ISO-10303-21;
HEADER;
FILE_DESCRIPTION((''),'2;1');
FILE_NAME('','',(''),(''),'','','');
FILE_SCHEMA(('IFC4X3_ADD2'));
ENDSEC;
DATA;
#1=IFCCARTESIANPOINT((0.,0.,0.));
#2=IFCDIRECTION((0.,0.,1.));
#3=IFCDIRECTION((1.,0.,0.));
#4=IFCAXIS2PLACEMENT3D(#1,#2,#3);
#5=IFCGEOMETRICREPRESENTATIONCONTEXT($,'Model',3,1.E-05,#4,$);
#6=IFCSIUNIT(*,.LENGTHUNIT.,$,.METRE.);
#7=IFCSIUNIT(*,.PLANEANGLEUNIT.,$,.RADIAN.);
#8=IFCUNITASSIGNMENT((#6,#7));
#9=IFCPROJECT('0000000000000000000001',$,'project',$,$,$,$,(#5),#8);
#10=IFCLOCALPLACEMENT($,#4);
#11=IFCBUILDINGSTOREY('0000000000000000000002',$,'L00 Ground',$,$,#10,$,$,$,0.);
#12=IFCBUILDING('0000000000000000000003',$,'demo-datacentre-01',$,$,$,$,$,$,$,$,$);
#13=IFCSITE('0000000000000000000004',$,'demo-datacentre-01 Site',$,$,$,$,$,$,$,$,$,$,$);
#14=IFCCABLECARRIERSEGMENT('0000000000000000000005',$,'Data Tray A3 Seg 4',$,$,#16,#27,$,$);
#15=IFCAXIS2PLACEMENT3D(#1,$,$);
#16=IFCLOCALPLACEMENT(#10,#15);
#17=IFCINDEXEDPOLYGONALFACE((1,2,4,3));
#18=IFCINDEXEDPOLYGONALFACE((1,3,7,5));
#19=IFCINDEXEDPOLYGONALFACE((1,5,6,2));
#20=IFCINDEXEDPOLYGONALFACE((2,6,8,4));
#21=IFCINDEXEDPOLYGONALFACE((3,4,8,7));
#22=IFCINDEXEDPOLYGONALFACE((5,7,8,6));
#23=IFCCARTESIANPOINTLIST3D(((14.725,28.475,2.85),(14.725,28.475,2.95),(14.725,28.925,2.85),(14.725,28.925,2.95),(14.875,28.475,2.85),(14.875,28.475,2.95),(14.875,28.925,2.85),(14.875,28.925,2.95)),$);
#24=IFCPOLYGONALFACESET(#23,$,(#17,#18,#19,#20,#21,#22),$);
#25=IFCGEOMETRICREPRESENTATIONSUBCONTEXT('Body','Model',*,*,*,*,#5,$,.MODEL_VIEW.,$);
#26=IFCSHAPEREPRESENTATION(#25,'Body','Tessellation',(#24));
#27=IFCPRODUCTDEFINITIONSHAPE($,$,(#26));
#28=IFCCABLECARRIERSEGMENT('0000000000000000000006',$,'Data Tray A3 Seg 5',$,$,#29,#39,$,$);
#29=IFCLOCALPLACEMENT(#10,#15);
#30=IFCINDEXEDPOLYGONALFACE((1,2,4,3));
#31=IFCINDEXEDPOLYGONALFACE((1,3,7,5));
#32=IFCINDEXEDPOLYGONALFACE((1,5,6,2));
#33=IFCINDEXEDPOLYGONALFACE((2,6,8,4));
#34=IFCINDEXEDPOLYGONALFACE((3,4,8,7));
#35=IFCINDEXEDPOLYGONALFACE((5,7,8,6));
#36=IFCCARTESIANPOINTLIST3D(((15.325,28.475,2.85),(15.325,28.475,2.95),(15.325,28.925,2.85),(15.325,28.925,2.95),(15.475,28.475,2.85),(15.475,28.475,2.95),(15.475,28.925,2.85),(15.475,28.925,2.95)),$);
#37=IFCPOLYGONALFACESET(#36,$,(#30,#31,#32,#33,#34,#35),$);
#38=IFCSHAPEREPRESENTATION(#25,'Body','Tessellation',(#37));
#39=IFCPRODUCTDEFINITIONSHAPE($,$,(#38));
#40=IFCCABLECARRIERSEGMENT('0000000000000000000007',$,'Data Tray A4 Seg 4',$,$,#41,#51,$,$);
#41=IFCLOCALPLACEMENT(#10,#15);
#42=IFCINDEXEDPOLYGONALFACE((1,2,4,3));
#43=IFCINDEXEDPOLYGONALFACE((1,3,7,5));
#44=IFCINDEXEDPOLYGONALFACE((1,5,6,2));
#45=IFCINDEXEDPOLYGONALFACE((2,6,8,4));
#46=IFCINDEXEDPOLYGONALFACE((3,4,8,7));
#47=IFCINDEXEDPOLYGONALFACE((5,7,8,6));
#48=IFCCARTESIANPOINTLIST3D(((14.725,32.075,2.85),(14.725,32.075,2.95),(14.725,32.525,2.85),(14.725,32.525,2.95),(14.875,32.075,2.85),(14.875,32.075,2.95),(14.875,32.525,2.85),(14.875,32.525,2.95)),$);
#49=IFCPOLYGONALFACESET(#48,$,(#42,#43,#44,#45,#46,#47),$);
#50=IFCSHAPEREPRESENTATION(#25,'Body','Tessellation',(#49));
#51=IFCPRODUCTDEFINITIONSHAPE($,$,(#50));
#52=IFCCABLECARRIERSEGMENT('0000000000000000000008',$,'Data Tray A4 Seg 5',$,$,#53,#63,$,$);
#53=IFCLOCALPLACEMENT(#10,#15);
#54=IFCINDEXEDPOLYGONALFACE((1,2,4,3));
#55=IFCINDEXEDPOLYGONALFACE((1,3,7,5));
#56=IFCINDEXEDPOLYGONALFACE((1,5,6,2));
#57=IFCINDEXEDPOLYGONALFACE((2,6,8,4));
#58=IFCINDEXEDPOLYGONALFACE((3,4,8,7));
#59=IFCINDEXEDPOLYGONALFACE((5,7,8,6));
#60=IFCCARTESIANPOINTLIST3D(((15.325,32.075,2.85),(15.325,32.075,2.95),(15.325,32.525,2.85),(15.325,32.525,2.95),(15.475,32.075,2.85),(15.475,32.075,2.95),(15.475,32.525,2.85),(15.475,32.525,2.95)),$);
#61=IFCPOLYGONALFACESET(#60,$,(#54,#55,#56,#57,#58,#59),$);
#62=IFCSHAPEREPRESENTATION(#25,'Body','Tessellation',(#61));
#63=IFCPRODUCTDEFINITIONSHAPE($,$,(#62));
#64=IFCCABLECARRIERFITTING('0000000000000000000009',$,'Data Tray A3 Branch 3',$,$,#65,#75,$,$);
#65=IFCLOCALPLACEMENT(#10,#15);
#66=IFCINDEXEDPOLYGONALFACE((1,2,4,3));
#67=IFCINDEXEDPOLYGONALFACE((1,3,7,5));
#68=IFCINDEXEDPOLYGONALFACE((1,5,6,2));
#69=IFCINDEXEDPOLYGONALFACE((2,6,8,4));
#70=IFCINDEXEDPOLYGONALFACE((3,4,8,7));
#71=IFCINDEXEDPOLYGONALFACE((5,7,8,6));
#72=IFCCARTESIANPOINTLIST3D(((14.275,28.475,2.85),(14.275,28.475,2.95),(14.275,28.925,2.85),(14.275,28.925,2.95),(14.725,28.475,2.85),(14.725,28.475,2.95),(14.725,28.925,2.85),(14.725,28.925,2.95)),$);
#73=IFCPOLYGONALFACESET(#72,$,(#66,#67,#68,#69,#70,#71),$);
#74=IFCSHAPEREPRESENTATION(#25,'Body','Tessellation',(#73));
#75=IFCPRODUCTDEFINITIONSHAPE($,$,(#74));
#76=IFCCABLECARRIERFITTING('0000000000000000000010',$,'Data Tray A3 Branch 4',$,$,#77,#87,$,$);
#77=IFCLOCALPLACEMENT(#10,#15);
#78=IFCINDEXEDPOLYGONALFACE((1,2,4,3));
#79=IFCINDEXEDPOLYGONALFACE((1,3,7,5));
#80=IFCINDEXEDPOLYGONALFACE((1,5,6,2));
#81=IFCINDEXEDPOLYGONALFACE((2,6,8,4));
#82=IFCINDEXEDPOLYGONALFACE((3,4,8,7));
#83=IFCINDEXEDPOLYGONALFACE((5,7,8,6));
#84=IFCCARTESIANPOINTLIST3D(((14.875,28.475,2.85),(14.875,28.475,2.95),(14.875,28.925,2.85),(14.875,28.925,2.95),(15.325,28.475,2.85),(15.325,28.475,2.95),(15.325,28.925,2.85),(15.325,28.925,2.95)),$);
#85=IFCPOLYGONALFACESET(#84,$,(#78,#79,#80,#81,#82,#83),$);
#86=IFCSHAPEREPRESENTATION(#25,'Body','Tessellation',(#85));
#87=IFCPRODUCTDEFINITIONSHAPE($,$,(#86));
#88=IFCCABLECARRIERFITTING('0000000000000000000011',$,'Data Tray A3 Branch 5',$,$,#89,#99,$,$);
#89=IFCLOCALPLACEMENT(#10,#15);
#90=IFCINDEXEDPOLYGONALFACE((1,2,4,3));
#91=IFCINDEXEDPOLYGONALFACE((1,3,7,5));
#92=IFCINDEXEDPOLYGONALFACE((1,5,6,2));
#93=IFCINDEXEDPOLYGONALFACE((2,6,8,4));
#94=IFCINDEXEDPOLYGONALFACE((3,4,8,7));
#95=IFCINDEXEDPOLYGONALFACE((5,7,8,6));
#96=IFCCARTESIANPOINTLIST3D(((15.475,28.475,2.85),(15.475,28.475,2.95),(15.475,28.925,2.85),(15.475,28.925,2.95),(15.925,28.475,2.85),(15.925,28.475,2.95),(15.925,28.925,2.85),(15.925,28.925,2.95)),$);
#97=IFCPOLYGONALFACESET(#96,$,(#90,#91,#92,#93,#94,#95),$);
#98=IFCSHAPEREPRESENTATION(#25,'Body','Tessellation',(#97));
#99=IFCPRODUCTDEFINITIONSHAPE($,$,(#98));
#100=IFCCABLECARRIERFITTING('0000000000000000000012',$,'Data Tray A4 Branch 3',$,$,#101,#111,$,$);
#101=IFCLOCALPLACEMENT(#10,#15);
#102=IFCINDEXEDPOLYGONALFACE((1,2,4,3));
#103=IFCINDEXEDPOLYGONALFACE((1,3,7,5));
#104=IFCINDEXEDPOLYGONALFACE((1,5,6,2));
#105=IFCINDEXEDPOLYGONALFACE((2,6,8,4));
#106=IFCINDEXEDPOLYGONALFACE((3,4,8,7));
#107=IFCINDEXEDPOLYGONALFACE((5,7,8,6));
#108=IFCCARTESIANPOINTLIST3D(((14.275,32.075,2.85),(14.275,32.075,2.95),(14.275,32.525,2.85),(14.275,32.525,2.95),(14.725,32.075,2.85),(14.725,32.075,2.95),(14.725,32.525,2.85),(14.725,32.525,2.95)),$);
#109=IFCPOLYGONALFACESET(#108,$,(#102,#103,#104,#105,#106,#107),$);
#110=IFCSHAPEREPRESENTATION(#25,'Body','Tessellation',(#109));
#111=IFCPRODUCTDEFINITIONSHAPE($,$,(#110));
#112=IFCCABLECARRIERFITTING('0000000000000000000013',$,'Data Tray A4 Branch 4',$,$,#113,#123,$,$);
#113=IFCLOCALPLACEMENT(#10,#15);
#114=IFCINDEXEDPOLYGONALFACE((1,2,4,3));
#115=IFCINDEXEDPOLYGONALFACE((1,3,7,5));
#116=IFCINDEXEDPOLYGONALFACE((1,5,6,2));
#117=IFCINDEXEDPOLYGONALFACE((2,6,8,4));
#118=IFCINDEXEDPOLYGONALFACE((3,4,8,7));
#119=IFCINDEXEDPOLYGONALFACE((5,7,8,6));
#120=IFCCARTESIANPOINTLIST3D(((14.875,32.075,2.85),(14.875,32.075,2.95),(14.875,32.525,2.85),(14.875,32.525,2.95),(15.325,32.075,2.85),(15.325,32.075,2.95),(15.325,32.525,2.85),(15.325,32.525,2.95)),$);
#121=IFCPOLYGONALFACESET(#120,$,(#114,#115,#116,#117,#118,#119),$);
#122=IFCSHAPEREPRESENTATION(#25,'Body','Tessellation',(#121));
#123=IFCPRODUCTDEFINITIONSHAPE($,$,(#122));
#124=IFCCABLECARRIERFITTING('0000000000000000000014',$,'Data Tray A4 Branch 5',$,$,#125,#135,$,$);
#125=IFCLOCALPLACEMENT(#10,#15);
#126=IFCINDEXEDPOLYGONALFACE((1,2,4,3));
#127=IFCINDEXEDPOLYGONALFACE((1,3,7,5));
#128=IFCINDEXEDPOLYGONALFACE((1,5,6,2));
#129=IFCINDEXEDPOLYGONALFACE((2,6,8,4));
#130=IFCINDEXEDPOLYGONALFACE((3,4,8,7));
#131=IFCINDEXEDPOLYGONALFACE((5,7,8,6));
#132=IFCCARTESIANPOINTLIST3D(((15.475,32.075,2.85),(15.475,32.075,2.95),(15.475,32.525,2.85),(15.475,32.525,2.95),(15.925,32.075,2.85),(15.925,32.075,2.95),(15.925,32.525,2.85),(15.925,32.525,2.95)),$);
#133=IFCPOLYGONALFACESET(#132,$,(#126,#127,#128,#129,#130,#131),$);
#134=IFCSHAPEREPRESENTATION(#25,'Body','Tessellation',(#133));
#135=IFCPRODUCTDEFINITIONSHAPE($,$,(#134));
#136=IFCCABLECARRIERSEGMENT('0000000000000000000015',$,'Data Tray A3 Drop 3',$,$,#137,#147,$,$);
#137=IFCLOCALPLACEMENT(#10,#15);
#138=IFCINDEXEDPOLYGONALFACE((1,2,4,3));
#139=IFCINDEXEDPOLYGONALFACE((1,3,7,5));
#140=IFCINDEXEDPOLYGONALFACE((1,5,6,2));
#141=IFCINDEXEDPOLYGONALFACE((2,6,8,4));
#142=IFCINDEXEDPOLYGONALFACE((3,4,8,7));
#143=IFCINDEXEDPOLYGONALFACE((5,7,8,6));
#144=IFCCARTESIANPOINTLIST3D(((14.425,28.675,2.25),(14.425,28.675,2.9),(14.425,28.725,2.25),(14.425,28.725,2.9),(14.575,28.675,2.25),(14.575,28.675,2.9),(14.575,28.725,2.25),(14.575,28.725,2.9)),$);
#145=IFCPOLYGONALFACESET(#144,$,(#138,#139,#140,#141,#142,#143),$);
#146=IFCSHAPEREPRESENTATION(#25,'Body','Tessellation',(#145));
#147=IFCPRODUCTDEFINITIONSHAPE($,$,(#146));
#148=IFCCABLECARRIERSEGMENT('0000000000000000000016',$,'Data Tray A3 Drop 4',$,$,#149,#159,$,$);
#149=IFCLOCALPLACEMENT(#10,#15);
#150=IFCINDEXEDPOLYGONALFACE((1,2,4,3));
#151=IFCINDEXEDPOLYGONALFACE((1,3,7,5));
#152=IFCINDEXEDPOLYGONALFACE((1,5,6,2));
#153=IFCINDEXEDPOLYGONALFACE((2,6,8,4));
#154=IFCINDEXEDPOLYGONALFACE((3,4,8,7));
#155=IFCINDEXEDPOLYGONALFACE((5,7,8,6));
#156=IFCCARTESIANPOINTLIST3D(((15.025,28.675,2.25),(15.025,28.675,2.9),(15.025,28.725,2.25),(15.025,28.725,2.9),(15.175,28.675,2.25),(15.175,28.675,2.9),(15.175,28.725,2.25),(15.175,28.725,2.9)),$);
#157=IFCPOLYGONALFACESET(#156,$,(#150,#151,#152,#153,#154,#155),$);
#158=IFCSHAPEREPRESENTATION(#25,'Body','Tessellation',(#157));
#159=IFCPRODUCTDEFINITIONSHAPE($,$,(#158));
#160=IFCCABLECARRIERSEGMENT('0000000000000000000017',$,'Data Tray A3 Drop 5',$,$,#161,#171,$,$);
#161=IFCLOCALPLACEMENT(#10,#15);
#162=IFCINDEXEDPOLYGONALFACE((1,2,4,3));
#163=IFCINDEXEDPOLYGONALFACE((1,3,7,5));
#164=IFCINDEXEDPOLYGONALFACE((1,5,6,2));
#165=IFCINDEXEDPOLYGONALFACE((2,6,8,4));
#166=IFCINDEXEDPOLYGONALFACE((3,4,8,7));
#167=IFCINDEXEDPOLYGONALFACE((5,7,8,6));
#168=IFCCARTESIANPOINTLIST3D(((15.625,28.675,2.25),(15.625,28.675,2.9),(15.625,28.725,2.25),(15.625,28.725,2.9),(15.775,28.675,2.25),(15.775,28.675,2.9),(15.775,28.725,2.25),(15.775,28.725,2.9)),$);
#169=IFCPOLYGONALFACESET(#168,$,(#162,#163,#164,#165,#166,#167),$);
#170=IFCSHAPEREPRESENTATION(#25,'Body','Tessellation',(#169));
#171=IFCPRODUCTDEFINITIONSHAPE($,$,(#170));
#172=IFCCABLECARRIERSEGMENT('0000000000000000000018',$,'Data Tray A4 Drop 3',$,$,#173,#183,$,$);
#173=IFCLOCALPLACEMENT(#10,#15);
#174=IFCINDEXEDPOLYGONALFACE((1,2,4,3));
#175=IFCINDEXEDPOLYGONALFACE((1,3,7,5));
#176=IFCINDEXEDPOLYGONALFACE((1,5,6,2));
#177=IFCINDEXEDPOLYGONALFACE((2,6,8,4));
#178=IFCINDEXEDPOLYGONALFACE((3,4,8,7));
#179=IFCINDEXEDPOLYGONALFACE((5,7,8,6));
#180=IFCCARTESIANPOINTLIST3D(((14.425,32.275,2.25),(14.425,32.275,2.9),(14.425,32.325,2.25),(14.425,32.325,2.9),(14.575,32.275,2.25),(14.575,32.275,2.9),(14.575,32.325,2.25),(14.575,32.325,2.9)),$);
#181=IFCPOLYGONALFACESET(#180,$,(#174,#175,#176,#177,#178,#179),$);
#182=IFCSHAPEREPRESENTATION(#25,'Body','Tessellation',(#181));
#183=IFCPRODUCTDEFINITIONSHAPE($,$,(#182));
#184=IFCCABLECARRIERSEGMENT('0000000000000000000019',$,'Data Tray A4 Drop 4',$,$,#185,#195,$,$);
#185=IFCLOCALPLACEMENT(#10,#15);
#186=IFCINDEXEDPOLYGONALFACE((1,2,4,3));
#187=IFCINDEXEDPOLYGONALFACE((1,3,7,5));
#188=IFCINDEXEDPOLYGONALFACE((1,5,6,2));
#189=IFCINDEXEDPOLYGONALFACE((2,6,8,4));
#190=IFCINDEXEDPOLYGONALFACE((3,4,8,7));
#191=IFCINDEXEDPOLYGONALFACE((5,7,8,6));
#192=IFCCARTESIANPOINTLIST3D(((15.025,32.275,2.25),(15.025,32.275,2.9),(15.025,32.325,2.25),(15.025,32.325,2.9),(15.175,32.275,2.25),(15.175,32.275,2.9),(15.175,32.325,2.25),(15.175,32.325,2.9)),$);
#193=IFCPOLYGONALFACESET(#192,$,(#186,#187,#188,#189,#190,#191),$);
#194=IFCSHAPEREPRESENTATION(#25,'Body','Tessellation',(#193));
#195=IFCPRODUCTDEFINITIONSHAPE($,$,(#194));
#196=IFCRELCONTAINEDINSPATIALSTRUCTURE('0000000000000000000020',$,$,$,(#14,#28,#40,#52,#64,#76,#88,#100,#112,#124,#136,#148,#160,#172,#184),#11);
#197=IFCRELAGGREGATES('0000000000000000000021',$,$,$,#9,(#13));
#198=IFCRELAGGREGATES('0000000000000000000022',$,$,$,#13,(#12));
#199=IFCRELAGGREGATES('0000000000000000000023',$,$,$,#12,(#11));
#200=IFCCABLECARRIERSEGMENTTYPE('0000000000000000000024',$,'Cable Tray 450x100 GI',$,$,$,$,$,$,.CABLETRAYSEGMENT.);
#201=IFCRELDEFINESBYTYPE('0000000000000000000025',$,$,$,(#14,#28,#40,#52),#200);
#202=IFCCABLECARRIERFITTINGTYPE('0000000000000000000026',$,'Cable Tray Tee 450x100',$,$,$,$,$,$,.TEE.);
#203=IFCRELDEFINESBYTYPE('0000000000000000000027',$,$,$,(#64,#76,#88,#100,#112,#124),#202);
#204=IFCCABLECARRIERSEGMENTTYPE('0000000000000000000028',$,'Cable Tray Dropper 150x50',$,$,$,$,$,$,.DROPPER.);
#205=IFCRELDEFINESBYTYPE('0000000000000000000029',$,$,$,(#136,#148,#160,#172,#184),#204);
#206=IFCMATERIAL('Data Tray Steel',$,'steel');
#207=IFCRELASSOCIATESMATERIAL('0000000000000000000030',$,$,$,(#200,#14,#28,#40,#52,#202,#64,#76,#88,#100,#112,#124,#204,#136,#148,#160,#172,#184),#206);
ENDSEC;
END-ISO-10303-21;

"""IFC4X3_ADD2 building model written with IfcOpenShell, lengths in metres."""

from ifc_helpers import new_model, si_unit, frame, origin_with_axes, place, context, subcontext, project, spatial, rectangle, extrude, material, type_object, element, save


model = new_model("IFC4X3_ADD2")

# Units and contexts
model_context = context("Model", 3, precision=1e-05, world=origin_with_axes())
body_context = subcontext(model_context, "Body", "Model", "MODEL_VIEW")
ifc_project = project(units=[si_unit("LENGTHUNIT", "METRE"), si_unit("PLANEANGLEUNIT", "RADIAN")], contexts=[model_context])

# Site, building, storey
site = spatial("IfcSite", under=ifc_project, Name="demo-datacentre-01 Site")
building = spatial("IfcBuilding", under=site, Name="demo-datacentre-01")
storey_placement = place(None, origin_with_axes())
storey = spatial("IfcBuildingStorey", under=building, at=storey_placement, Name="L00 Ground", Elevation=0.0)

# Cable carrier segments
ifc_material_1 = material(Name="Data Tray Steel", Category="steel")
cable_carrier_segment_type_1 = type_object("IfcCableCarrierSegmentType", Name="Cable Tray 450x100 GI", PredefinedType="CABLETRAYSEGMENT", material=ifc_material_1)
cable_carrier_segment_1_placement = place(storey_placement, frame((14.725, 28.7, 2.9), z_axis=(1.0, 0.0, 0.0), x_axis=(0.0, 1.0, 0.0)))
element("IfcCableCarrierSegment", 1, at=cable_carrier_segment_1_placement, inside=storey, type_object=cable_carrier_segment_type_1, material=ifc_material_1, Name="Data Tray A3 Seg 4", context=body_context, shape_type="SweptSolid", body=[
    extrude(rectangle(XDim=0.45, YDim=0.1), origin_with_axes(), (0.0, 0.0, 1.0), 0.15),
])
cable_carrier_segment_2_placement = place(storey_placement, frame((15.325, 28.7, 2.9), z_axis=(1.0, 0.0, 0.0), x_axis=(0.0, 1.0, 0.0)))
element("IfcCableCarrierSegment", 2, at=cable_carrier_segment_2_placement, inside=storey, type_object=cable_carrier_segment_type_1, material=ifc_material_1, Name="Data Tray A3 Seg 5", context=body_context, shape_type="SweptSolid", body=[
    extrude(rectangle(XDim=0.45, YDim=0.1), origin_with_axes(), (0.0, 0.0, 1.0), 0.15),
])
cable_carrier_segment_3_placement = place(storey_placement, frame((14.725, 32.3, 2.9), z_axis=(1.0, 0.0, 0.0), x_axis=(0.0, 1.0, 0.0)))
element("IfcCableCarrierSegment", 3, at=cable_carrier_segment_3_placement, inside=storey, type_object=cable_carrier_segment_type_1, material=ifc_material_1, Name="Data Tray A4 Seg 4", context=body_context, shape_type="SweptSolid", body=[
    extrude(rectangle(XDim=0.45, YDim=0.1), origin_with_axes(), (0.0, 0.0, 1.0), 0.15),
])
cable_carrier_segment_4_placement = place(storey_placement, frame((15.325, 32.3, 2.9), z_axis=(1.0, 0.0, 0.0), x_axis=(0.0, 1.0, 0.0)))
element("IfcCableCarrierSegment", 4, at=cable_carrier_segment_4_placement, inside=storey, type_object=cable_carrier_segment_type_1, material=ifc_material_1, Name="Data Tray A4 Seg 5", context=body_context, shape_type="SweptSolid", body=[
    extrude(rectangle(XDim=0.45, YDim=0.1), origin_with_axes(), (0.0, 0.0, 1.0), 0.15),
])

# Cable carrier fittings
cable_carrier_fitting_type = type_object("IfcCableCarrierFittingType", Name="Cable Tray Tee 450x100", PredefinedType="TEE", material=ifc_material_1)
for number, where, z_axis, x_axis, name in (
    (5, (14.5, 28.7, 2.85), (0.0, 0.0, 1.0), (1.0, 0.0, 0.0), "Data Tray A3 Branch 3"),
    (6, (15.1, 28.7, 2.85), (0.0, 0.0, 1.0), (1.0, 0.0, 0.0), "Data Tray A3 Branch 4"),
    (7, (15.7, 28.7, 2.85), (0.0, 0.0, 1.0), (1.0, 0.0, 0.0), "Data Tray A3 Branch 5"),
    (8, (14.5, 32.3, 2.85), (0.0, 0.0, 1.0), (1.0, 0.0, 0.0), "Data Tray A4 Branch 3"),
    (9, (15.1, 32.3, 2.85), (0.0, 0.0, 1.0), (1.0, 0.0, 0.0), "Data Tray A4 Branch 4"),
    (10, (15.7, 32.3, 2.85), (0.0, 0.0, 1.0), (1.0, 0.0, 0.0), "Data Tray A4 Branch 5"),
):
    element("IfcCableCarrierFitting", number, at=place(storey_placement, frame(where, z_axis=z_axis, x_axis=x_axis)), inside=storey, type_object=cable_carrier_fitting_type, material=ifc_material_1, Name=name, context=body_context, shape_type="SweptSolid", body=[
        extrude(rectangle(XDim=0.45, YDim=0.45), origin_with_axes(), (0.0, 0.0, 1.0), 0.1),
    ])

# Cable carrier segments
cable_carrier_segment_type_2 = type_object("IfcCableCarrierSegmentType", Name="Cable Tray Dropper 150x50", PredefinedType="DROPPER", material=ifc_material_1)
for number, where, z_axis, x_axis, name in (
    (11, (14.5, 28.7, 2.9), (0.0, 0.0, -1.0), (1.0, 0.0, 0.0), "Data Tray A3 Drop 3"),
    (12, (15.1, 28.7, 2.9), (0.0, 0.0, -1.0), (1.0, 0.0, 0.0), "Data Tray A3 Drop 4"),
    (13, (15.7, 28.7, 2.9), (0.0, 0.0, -1.0), (1.0, 0.0, 0.0), "Data Tray A3 Drop 5"),
    (14, (14.5, 32.3, 2.9), (0.0, 0.0, -1.0), (1.0, 0.0, 0.0), "Data Tray A4 Drop 3"),
    (15, (15.1, 32.3, 2.9), (0.0, 0.0, -1.0), (1.0, 0.0, 0.0), "Data Tray A4 Drop 4"),
):
    element("IfcCableCarrierSegment", number, at=place(storey_placement, frame(where, z_axis=z_axis, x_axis=x_axis)), inside=storey, type_object=cable_carrier_segment_type_2, material=ifc_material_1, Name=name, context=body_context, shape_type="SweptSolid", body=[
        extrude(rectangle(XDim=0.15, YDim=0.05), origin_with_axes(), (0.0, 0.0, 1.0), 0.65),
    ])

save(model, "model.ifc")
